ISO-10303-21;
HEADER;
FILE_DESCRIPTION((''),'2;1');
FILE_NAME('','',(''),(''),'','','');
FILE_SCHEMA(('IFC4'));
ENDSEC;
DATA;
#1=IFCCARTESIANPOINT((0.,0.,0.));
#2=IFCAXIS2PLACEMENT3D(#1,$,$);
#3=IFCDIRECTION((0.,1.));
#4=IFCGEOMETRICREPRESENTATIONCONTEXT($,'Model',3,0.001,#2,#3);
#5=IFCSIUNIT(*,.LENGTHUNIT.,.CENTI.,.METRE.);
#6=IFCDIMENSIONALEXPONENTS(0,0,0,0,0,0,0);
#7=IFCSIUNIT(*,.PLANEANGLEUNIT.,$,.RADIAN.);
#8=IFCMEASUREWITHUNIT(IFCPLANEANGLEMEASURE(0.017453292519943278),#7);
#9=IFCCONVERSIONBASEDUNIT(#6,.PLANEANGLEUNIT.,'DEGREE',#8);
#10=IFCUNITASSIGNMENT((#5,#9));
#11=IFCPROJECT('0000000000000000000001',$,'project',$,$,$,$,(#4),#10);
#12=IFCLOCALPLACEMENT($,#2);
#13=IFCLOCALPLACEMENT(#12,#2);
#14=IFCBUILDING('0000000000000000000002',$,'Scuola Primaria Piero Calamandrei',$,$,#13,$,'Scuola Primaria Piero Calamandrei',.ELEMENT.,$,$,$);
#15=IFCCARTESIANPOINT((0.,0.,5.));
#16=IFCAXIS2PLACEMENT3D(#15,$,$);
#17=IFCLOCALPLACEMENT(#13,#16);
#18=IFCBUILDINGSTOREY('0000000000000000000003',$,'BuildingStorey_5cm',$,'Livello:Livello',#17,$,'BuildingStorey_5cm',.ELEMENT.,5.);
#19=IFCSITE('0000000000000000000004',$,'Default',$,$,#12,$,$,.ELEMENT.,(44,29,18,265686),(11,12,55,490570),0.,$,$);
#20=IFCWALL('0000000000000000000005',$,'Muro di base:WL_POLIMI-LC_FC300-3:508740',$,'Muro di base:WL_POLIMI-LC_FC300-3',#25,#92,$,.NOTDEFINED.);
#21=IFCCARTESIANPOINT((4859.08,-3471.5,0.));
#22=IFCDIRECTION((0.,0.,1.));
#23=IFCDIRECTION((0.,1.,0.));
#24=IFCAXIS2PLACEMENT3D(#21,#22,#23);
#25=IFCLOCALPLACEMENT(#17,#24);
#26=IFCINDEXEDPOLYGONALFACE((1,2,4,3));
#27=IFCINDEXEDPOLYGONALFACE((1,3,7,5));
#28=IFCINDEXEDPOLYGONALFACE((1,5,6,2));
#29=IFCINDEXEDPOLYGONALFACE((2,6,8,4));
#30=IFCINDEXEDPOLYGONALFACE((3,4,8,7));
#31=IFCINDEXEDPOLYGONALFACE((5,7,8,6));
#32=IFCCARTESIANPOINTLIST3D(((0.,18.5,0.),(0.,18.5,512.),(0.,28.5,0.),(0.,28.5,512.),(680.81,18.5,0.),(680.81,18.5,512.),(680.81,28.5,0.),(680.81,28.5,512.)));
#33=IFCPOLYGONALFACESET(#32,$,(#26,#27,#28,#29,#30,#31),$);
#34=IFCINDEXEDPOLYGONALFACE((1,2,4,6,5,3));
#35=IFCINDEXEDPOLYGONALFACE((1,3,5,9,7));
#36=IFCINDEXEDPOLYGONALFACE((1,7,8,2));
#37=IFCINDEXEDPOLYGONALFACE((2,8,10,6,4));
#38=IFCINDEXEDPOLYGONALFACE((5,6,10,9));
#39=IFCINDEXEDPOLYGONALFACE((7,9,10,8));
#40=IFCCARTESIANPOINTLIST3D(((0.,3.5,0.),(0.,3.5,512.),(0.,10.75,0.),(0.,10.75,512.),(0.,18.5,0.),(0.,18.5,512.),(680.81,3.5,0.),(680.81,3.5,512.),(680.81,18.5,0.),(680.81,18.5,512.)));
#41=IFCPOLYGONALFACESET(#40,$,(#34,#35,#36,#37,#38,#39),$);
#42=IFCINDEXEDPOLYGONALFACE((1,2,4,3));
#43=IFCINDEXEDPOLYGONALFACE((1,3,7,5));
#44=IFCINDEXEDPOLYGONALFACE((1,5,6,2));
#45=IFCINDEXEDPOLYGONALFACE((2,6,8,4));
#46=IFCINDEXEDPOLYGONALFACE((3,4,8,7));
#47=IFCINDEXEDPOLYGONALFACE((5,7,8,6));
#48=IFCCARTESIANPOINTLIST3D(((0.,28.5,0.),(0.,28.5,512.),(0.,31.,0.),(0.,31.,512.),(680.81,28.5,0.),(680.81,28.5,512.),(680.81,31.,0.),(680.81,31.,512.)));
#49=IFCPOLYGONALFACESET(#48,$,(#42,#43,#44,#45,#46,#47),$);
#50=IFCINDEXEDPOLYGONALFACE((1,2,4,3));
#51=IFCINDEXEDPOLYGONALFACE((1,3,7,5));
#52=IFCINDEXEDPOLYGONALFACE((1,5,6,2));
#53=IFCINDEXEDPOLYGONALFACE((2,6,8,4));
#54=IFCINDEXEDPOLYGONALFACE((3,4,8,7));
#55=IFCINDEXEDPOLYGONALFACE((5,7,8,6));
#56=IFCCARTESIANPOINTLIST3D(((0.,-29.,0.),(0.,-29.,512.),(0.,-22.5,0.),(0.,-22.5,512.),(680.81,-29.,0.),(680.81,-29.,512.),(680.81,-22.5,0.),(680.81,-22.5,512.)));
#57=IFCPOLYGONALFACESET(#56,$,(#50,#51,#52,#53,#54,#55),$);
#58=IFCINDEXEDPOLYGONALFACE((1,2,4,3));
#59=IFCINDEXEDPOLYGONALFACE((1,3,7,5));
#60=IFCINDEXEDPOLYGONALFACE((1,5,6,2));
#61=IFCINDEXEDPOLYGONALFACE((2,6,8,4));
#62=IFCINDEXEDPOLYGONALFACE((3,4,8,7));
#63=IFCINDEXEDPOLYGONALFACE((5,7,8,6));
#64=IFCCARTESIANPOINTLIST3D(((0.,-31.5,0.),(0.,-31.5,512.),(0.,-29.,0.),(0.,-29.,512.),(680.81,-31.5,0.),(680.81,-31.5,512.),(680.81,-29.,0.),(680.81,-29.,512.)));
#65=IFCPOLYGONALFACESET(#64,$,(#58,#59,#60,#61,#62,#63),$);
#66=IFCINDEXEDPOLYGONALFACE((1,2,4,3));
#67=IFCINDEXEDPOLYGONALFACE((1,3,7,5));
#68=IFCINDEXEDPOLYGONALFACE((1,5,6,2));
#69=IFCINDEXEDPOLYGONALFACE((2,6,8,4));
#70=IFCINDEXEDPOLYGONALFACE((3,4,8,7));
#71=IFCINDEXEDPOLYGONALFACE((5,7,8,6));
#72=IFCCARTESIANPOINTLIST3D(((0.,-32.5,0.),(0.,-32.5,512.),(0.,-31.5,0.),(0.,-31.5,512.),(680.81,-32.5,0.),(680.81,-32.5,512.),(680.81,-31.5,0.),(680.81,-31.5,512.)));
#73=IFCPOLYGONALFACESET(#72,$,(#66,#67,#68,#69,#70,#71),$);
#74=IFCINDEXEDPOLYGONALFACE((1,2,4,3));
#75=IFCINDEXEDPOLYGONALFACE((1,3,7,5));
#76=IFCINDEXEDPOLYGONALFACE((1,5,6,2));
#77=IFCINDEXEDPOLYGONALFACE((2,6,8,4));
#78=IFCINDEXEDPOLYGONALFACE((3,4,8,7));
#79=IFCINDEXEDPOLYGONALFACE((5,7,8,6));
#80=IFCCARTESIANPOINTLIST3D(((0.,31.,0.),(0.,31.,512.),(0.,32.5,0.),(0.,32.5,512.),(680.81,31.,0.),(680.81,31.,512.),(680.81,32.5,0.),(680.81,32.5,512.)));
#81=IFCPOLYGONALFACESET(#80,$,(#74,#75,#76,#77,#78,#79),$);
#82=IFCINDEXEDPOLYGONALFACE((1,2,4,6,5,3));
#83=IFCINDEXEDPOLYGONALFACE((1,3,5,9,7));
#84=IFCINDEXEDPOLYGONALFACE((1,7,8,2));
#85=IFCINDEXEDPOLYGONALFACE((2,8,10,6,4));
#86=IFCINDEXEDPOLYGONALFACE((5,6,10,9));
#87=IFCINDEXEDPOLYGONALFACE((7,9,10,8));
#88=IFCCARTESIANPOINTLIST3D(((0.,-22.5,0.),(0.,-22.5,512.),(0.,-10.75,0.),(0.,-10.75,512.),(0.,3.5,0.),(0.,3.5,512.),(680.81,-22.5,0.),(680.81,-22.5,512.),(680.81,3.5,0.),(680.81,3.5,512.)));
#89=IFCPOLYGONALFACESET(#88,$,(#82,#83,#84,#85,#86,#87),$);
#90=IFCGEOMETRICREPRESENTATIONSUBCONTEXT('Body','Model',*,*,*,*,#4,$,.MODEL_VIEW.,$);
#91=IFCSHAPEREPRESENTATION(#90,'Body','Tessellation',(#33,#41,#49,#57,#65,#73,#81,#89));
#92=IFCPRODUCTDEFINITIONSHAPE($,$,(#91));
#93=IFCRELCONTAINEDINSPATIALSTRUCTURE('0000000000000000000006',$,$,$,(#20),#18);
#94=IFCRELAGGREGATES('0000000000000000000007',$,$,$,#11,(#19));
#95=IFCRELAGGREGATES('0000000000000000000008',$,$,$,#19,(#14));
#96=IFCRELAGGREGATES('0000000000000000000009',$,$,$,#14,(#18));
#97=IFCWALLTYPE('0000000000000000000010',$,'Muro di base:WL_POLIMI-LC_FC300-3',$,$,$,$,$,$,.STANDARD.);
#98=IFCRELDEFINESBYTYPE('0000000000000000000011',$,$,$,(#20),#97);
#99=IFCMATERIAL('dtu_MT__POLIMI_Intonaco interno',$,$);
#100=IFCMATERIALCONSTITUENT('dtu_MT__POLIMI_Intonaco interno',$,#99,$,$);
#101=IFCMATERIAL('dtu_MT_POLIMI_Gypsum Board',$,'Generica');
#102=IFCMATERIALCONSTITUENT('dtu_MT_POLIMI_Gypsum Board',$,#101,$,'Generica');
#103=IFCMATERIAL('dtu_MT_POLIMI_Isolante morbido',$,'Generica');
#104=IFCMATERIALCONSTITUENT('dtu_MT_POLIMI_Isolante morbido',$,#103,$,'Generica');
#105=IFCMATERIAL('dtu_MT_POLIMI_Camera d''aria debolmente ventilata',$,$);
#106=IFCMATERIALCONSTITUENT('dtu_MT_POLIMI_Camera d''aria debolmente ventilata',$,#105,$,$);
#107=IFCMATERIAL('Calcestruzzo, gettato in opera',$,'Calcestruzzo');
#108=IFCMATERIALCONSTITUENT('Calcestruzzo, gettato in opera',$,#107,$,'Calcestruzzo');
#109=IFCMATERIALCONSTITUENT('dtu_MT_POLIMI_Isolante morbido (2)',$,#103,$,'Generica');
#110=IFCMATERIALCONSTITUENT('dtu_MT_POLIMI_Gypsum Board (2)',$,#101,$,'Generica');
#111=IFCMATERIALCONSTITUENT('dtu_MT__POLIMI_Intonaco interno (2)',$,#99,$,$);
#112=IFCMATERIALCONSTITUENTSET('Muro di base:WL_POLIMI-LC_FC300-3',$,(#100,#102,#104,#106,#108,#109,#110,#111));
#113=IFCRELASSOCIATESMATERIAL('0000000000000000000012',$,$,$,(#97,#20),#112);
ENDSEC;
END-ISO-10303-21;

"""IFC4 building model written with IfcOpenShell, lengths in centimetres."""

from ifc_helpers import new_model, entity, si_unit, converted_unit, direction, frame, origin, place, context, subcontext, project, spatial, indexed_curve, outline, extrude, material, constituent, constituent_set, type_object, element, save


model = new_model("IFC4")

# Units and contexts
model_context = context("Model", 3, precision=0.001, world=origin(), true_north=direction((0.0, 1.0)))
body_context = subcontext(model_context, "Body", "Model", "MODEL_VIEW")
ifc_project = project(units=[si_unit("LENGTHUNIT", "METRE", prefix="CENTI"), converted_unit("PLANEANGLEUNIT", "DEGREE", entity("IfcPlaneAngleMeasure", 0.017453292519943278), si_unit("PLANEANGLEUNIT", "RADIAN"), dimensions=[0, 0, 0, 0, 0, 0, 0])], contexts=[model_context])

# Site, building, storey
site_placement = place(None, origin())
site = spatial("IfcSite", under=ifc_project, at=site_placement, Name="Default", CompositionType="ELEMENT", RefLatitude=(44, 29, 18, 265686), RefLongitude=(11, 12, 55, 490570), RefElevation=0.0)
building_placement = place(site_placement, origin())
building = spatial("IfcBuilding", under=site, at=building_placement, Name="Scuola Primaria Piero Calamandrei", LongName="Scuola Primaria Piero Calamandrei", CompositionType="ELEMENT")
storey_placement = place(building_placement, frame((0.0, 0.0, 5.0)))
storey = spatial("IfcBuildingStorey", under=building, at=storey_placement, Name="BuildingStorey_5cm", ObjectType="Livello:Livello", LongName="BuildingStorey_5cm", CompositionType="ELEMENT", Elevation=5.0)

# Wall
ifc_material_1 = material(Name="dtu_MT_POLIMI_Camera d'aria debolmente ventilata")
ifc_material_2 = material(Name="dtu_MT_POLIMI_Isolante morbido", Category="Generica")
ifc_material_3 = material(Name="dtu_MT_POLIMI_Gypsum Board", Category="Generica")
ifc_material_4 = material(Name="dtu_MT__POLIMI_Intonaco interno")
ifc_constituent_1 = constituent(ifc_material_4, Name="dtu_MT__POLIMI_Intonaco interno")
ifc_constituent_2 = constituent(ifc_material_3, Name="dtu_MT_POLIMI_Gypsum Board", Category="Generica")
ifc_constituent_3 = constituent(ifc_material_2, Name="dtu_MT_POLIMI_Isolante morbido", Category="Generica")
ifc_constituent_4 = constituent(ifc_material_1, Name="dtu_MT_POLIMI_Camera d'aria debolmente ventilata")
ifc_material_5 = material(Name="Calcestruzzo, gettato in opera", Category="Calcestruzzo")
ifc_constituent_5 = constituent(ifc_material_5, Name="Calcestruzzo, gettato in opera", Category="Calcestruzzo")
ifc_constituent_6 = constituent(ifc_material_2, Name="dtu_MT_POLIMI_Isolante morbido (2)", Category="Generica")
ifc_constituent_7 = constituent(ifc_material_3, Name="dtu_MT_POLIMI_Gypsum Board (2)", Category="Generica")
ifc_constituent_8 = constituent(ifc_material_4, Name="dtu_MT__POLIMI_Intonaco interno (2)")
ifc_constituent_set_1 = constituent_set(constituents=[ifc_constituent_1, ifc_constituent_2, ifc_constituent_3, ifc_constituent_4, ifc_constituent_5, ifc_constituent_6, ifc_constituent_7, ifc_constituent_8], Name="Muro di base:WL_POLIMI-LC_FC300-3")
wall_type_1 = type_object("IfcWallType", Name="Muro di base:WL_POLIMI-LC_FC300-3", PredefinedType="STANDARD", material=ifc_constituent_set_1)
wall_1_placement = place(storey_placement, frame((4859.08, -3471.5, 0.0), z_axis=(0.0, 0.0, 1.0), x_axis=(0.0, 1.0, 0.0)))
element("IfcWall", 1, at=wall_1_placement, inside=storey, type_object=wall_type_1, material=ifc_constituent_set_1, Name="Muro di base:WL_POLIMI-LC_FC300-3:508740", ObjectType="Muro di base:WL_POLIMI-LC_FC300-3", PredefinedType="NOTDEFINED", context=body_context, shape_type="SweptSolid", body=[
    extrude(outline(indexed_curve([(-340.41, -5.0), (340.41, -5.0), (340.41, 5.0), (-340.41, 5.0), (-340.41, -5.0)], self_intersect=False)), frame((340.41, 23.5, 0.0)), (0.0, 0.0, 1.0), 512.0),
    extrude(outline(indexed_curve([(-272.33, -7.45), (408.49, -7.45), (408.49, 7.55), (-272.33, 7.55), (-272.33, -0.2), (-272.33, -7.45)], self_intersect=False)), frame((272.33, 10.95, 0.0)), (0.0, 0.0, 1.0), 512.0),
    extrude(outline(indexed_curve([(-340.41, -1.25), (340.41, -1.25), (340.41, 1.25), (-340.41, 1.25), (-340.41, -1.25)], self_intersect=False)), frame((340.41, 29.75, 0.0)), (0.0, 0.0, 1.0), 512.0),
    extrude(outline(indexed_curve([(-340.41, -3.25), (340.41, -3.25), (340.41, 3.25), (-340.41, 3.25), (-340.41, -3.25)], self_intersect=False)), frame((340.41, -25.75, 0.0)), (0.0, 0.0, 1.0), 512.0),
    extrude(outline(indexed_curve([(-340.41, -1.25), (340.41, -1.25), (340.41, 1.25), (-340.41, 1.25), (-340.41, -1.25)], self_intersect=False)), frame((340.41, -30.25, 0.0)), (0.0, 0.0, 1.0), 512.0),
    extrude(outline(indexed_curve([(-0.5, -340.41), (0.5, -340.41), (0.5, 340.41), (-0.5, 340.41), (-0.5, -340.41)], self_intersect=False)), frame((340.41, -32.0, 0.0), z_axis=(0.0, 0.0, 1.0), x_axis=(0.0, 1.0, 0.0)), (0.0, 0.0, 1.0), 512.0),
    extrude(outline(indexed_curve([(-0.75, -340.41), (0.75, -340.41), (0.75, 340.41), (-0.75, 340.41), (-0.75, -340.41)], self_intersect=False)), frame((340.41, 31.75, 0.0), z_axis=(0.0, 0.0, 1.0), x_axis=(0.0, -1.0, 0.0)), (0.0, 0.0, 1.0), 512.0),
    extrude(outline(indexed_curve([(-272.33, -12.75), (408.49, -12.75), (408.49, 13.25), (-272.33, 13.25), (-272.33, -1.0), (-272.33, -12.75)], self_intersect=False)), frame((272.33, -9.75, 0.0)), (0.0, 0.0, 1.0), 512.0),
])

save(model, "model.ifc")
